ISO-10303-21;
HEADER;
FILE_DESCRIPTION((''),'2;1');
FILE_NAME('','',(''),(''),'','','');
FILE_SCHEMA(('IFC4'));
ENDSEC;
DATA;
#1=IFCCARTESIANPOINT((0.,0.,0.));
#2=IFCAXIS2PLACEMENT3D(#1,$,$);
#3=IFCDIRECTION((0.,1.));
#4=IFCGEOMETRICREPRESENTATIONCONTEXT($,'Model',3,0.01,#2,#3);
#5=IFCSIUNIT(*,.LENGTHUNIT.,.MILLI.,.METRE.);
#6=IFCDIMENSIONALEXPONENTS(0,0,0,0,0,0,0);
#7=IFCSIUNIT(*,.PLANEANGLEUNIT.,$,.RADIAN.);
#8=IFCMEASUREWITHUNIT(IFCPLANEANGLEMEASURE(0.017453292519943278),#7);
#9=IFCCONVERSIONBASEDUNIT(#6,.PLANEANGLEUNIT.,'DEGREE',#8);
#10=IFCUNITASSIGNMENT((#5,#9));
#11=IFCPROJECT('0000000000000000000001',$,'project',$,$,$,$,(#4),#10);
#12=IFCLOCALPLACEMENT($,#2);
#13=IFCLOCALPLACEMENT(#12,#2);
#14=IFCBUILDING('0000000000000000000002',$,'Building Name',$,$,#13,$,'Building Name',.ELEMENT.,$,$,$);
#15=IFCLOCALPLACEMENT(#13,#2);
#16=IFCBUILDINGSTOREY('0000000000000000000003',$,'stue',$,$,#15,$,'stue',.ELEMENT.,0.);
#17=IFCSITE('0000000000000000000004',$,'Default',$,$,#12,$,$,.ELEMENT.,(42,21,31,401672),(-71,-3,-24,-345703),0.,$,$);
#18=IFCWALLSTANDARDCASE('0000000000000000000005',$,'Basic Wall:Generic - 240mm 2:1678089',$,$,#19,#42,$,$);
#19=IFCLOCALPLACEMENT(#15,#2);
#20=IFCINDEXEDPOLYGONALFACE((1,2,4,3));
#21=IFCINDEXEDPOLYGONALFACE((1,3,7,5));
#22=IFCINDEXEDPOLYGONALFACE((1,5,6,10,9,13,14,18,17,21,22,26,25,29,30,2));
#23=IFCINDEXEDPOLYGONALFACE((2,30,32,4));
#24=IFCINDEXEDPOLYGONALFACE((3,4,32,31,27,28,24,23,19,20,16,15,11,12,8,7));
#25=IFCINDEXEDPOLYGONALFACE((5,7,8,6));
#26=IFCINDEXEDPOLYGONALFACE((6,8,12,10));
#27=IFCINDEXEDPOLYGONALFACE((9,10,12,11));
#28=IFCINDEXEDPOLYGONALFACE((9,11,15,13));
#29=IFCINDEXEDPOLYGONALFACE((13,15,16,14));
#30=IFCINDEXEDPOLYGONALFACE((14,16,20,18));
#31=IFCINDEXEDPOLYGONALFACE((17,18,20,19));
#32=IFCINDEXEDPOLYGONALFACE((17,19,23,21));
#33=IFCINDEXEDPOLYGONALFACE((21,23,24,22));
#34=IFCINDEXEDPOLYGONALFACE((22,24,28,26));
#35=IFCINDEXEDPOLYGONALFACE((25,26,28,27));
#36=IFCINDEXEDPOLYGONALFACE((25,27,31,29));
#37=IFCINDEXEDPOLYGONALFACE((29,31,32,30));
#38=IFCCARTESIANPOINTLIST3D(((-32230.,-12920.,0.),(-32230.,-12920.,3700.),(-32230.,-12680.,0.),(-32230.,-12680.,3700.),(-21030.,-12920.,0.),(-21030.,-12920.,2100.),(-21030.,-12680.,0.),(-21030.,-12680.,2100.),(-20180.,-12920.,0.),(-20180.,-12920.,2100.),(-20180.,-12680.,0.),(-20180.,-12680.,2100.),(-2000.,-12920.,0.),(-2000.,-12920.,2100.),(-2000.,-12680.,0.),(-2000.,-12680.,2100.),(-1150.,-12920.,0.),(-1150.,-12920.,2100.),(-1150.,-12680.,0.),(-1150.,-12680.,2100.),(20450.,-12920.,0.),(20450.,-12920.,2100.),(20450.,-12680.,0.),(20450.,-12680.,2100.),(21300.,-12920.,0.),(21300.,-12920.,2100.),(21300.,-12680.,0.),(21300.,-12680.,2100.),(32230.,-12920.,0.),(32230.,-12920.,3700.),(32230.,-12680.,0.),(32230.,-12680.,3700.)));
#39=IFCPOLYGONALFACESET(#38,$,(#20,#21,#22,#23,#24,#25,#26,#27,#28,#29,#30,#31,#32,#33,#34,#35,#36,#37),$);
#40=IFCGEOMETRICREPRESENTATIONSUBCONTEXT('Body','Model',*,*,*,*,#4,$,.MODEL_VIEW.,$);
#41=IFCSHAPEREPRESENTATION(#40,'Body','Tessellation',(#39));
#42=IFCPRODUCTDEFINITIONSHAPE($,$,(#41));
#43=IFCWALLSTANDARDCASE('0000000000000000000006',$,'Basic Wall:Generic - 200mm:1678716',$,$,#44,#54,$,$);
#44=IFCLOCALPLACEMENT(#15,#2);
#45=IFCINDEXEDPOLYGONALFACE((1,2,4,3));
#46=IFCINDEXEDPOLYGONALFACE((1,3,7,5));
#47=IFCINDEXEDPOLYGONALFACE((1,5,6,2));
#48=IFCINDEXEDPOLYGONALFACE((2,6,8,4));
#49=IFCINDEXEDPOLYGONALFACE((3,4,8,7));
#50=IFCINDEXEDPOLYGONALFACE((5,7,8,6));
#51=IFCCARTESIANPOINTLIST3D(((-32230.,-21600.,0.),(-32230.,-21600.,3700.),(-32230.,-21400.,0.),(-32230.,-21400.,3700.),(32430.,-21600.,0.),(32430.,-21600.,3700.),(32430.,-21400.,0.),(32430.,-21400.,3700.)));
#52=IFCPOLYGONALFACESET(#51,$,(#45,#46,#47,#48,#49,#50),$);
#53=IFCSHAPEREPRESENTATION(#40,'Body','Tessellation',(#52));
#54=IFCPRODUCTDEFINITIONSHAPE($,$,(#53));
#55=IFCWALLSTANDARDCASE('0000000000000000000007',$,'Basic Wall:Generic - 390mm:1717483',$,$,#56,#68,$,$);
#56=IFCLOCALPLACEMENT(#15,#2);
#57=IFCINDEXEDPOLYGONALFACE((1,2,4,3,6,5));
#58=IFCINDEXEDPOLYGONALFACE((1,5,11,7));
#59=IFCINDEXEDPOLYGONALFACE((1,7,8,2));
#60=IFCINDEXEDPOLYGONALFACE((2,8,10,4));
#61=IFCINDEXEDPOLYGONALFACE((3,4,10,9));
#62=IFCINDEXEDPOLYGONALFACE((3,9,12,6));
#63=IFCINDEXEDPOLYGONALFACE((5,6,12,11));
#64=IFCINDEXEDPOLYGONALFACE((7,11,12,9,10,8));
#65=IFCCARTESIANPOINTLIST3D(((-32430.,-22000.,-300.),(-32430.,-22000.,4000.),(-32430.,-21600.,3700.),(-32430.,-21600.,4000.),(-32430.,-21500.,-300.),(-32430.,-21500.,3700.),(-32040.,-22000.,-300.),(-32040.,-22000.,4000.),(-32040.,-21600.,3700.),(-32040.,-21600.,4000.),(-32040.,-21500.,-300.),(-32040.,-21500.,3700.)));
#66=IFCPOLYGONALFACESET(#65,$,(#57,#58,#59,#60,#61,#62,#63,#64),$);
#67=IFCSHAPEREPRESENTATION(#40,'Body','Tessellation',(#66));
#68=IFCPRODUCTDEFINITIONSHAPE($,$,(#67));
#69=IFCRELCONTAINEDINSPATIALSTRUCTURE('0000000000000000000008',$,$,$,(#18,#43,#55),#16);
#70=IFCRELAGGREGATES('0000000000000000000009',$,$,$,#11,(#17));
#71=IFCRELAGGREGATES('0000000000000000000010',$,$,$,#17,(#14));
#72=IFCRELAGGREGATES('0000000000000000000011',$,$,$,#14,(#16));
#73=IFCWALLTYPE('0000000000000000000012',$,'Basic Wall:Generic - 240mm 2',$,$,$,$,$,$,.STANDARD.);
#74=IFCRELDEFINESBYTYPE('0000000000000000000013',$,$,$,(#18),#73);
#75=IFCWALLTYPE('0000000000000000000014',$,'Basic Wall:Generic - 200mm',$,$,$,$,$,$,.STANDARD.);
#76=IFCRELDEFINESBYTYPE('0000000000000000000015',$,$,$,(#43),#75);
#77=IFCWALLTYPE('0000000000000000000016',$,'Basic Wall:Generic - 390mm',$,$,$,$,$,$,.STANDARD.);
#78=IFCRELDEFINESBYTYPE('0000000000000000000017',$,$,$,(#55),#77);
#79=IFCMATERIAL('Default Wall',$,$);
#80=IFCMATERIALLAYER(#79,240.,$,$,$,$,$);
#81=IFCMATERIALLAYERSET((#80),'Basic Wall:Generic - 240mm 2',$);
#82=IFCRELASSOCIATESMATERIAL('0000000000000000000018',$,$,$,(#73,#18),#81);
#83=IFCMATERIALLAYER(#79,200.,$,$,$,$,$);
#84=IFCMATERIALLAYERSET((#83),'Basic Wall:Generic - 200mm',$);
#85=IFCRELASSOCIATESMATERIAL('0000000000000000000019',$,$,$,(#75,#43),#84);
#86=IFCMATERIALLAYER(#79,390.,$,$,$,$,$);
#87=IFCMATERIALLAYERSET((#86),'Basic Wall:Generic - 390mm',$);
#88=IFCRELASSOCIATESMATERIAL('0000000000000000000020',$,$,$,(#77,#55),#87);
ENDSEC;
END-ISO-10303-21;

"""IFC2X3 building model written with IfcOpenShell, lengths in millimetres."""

from ifc_helpers import new_model, entity, si_unit, converted_unit, direction, frame, frame_2d, origin, place, context, subcontext, project, spatial, polyline, rectangle, extrude, clip, bounded_halfspace, material, layer, layer_set, layer_usage, type_object, element, save


model = new_model("IFC2X3")

# Units and contexts
model_context = context("Model", 3, precision=0.01, world=origin(), true_north=direction((0.0, 1.0)))
body_context = subcontext(model_context, "Body", "Model", "MODEL_VIEW")
ifc_project = project(units=[si_unit("LENGTHUNIT", "METRE", prefix="MILLI"), converted_unit("PLANEANGLEUNIT", "DEGREE", entity("IfcPlaneAngleMeasure", 0.017453292519943278), si_unit("PLANEANGLEUNIT", "RADIAN"), dimensions=[0, 0, 0, 0, 0, 0, 0])], contexts=[model_context])

# Site, building, storey
site_placement = place(None, origin())
site = spatial("IfcSite", under=ifc_project, at=site_placement, Name="Default", CompositionType="ELEMENT", RefLatitude=(42, 21, 31, 401672), RefLongitude=(-71, -3, -24, -345703), RefElevation=0.0)
building_placement = place(site_placement, origin())
building = spatial("IfcBuilding", under=site, at=building_placement, Name="Building Name", LongName="Building Name", CompositionType="ELEMENT")
storey_placement = place(building_placement, origin())
storey = spatial("IfcBuildingStorey", under=building, at=storey_placement, Name="stue", LongName="stue", CompositionType="ELEMENT", Elevation=0.0)

# Wall, openings
ifc_material_1 = material(Name="Default Wall")
ifc_layer_1 = layer(ifc_material_1, 240.0)
ifc_layer_set_1 = layer_set([ifc_layer_1], Name="Basic Wall:Generic - 240mm 2")
ifc_layer_usage_1 = layer_usage(ifc_layer_set_1, "AXIS2", "NEGATIVE", 120.0)
wall_type_1 = type_object("IfcWallType", Name="Basic Wall:Generic - 240mm 2", PredefinedType="STANDARD", material=ifc_layer_set_1)
wall_1_placement = place(storey_placement, frame((-32230.0, -12800.0, 0.0)))
wall_1 = element("IfcWallStandardCase", 1, at=wall_1_placement, inside=storey, type_object=wall_type_1, material=ifc_layer_usage_1, Name="Basic Wall:Generic - 240mm 2:1678089", context=body_context, shape_type="Clipping", body=[
    clip(clip(clip(extrude(rectangle(XDim=64460.0, YDim=240.0, at=frame_2d((32230.0, 0.0), x_axis=(-1.0, 0.0))), origin(), (0.0, 0.0, 1.0), 3700.0), bounded_halfspace(frame((64460.0, -120.0, 3700.0), z_axis=(0.0, 0.0, -1.0), x_axis=(-1.0, 0.0, 0.0)), True, frame((64460.0, -120.0, 3700.0)), polyline([(0.0, 0.0), (0.0, 240.0), (-9735.0, 240.0), (-9735.0, 0.0), (0.0, 0.0)]))), bounded_halfspace(frame((3355.0, -120.0, 3700.0), z_axis=(0.0, 0.0, -1.0), x_axis=(0.0, -1.0, 0.0)), True, frame((3355.0, -120.0, 3700.0)), polyline([(0.0, 0.0), (41525.0, 0.0), (41825.0, 0.0), (51370.0, 0.0), (51370.0, 240.0), (0.0, 240.0), (0.0, 0.0)]))), bounded_halfspace(frame((0.0, 120.0, 3700.0), z_axis=(0.0, 0.0, -1.0), x_axis=(-1.0, 0.0, 0.0)), True, frame((0.0, 120.0, 3700.0)), polyline([(0.0, 0.0), (0.0, -240.0), (3355.0, -240.0), (3355.0, 0.0), (0.0, 0.0)]))),
])
opening_1_placement = place(wall_1_placement, frame((12050.0, 120.0, 0.0)))
element("IfcOpeningElement", 2, at=opening_1_placement, cuts=wall_1, ObjectType="Opening", context=body_context, shape_type="SweptSolid", body=[
    extrude(rectangle(XDim=2100.0, YDim=850.0, at=frame_2d((1050.0, 425.0), x_axis=(1.0, 0.0))), frame((0.0, 0.0, 0.0), z_axis=(0.0, -1.0, 0.0), x_axis=(0.0, 0.0, 1.0)), (0.0, 0.0, 1.0), 240.0),
])
opening_2_placement = place(wall_1_placement, frame((31080.0, 120.0, 0.0)))
element("IfcOpeningElement", 3, at=opening_2_placement, cuts=wall_1, ObjectType="Opening", context=body_context, shape_type="SweptSolid", body=[
    extrude(rectangle(XDim=2100.0, YDim=850.0, at=frame_2d((1050.0, 425.0), x_axis=(1.0, 0.0))), frame((0.0, 0.0, 0.0), z_axis=(0.0, -1.0, 0.0), x_axis=(0.0, 0.0, 1.0)), (0.0, 0.0, 1.0), 240.0),
])
opening_3_placement = place(wall_1_placement, frame((53530.0, 120.0, 0.0)))
element("IfcOpeningElement", 4, at=opening_3_placement, cuts=wall_1, ObjectType="Opening", context=body_context, shape_type="SweptSolid", body=[
    extrude(rectangle(XDim=2100.0, YDim=850.0, at=frame_2d((1050.0, 425.0), x_axis=(1.0, 0.0))), frame((0.0, 0.0, 0.0), z_axis=(0.0, -1.0, 0.0), x_axis=(0.0, 0.0, 1.0)), (0.0, 0.0, 1.0), 240.0),
])

# Walls
ifc_layer_2 = layer(ifc_material_1, 200.0)
ifc_layer_set_2 = layer_set([ifc_layer_2], Name="Basic Wall:Generic - 200mm")
ifc_layer_usage_2 = layer_usage(ifc_layer_set_2, "AXIS2", "NEGATIVE", 100.0)
wall_type_2 = type_object("IfcWallType", Name="Basic Wall:Generic - 200mm", PredefinedType="STANDARD", material=ifc_layer_set_2)
wall_2_placement = place(storey_placement, frame((-32230.0, -21500.0, 0.0)))
element("IfcWallStandardCase", 5, at=wall_2_placement, inside=storey, type_object=wall_type_2, material=ifc_layer_usage_2, Name="Basic Wall:Generic - 200mm:1678716", context=body_context, shape_type="Clipping", body=[
    clip(extrude(rectangle(XDim=64660.0, YDim=200.0, at=frame_2d((32330.0, 0.0), x_axis=(-1.0, 0.0))), origin(), (0.0, 0.0, 1.0), 3700.0), bounded_halfspace(frame((0.0, -100.0, 3700.0), z_axis=(0.0, 0.0, -1.0), x_axis=(-1.0, 0.0, 0.0)), True, frame((0.0, -100.0, 3700.0)), polyline([(0.0, 0.0), (64660.0, 0.0), (64660.0, 200.0), (64460.0, 200.0), (45180.0, 200.0), (44880.0, 200.0), (0.0, 200.0), (0.0, 0.0)]))),
])
ifc_layer_3 = layer(ifc_material_1, 390.0)
ifc_layer_set_3 = layer_set([ifc_layer_3], Name="Basic Wall:Generic - 390mm")
ifc_layer_usage_3 = layer_usage(ifc_layer_set_3, "AXIS2", "NEGATIVE", 195.0)
wall_type_3 = type_object("IfcWallType", Name="Basic Wall:Generic - 390mm", PredefinedType="STANDARD", material=ifc_layer_set_3)
wall_3_placement = place(storey_placement, frame((-32235.0, -21500.0, -300.0), z_axis=(0.0, 0.0, 1.0), x_axis=(0.0, -1.0, 0.0)))
element("IfcWallStandardCase", 6, at=wall_3_placement, inside=storey, type_object=wall_type_3, material=ifc_layer_usage_3, Name="Basic Wall:Generic - 390mm:1717483", context=body_context, shape_type="Clipping", body=[
    clip(extrude(rectangle(XDim=500.0, YDim=390.0, at=frame_2d((250.0, 0.0), x_axis=(-1.0, 0.0))), origin(), (0.0, 0.0, 1.0), 4300.0), bounded_halfspace(frame((0.0, -195.0, 4000.0), z_axis=(0.0, 0.0, -1.0), x_axis=(0.0, -1.0, 0.0)), True, frame((0.0, -195.0, 4000.0)), polyline([(0.0, 0.0), (100.0, 0.0), (100.0, 390.0), (0.0, 390.0), (0.0, 0.0)]))),
])

save(model, "model.ifc")
